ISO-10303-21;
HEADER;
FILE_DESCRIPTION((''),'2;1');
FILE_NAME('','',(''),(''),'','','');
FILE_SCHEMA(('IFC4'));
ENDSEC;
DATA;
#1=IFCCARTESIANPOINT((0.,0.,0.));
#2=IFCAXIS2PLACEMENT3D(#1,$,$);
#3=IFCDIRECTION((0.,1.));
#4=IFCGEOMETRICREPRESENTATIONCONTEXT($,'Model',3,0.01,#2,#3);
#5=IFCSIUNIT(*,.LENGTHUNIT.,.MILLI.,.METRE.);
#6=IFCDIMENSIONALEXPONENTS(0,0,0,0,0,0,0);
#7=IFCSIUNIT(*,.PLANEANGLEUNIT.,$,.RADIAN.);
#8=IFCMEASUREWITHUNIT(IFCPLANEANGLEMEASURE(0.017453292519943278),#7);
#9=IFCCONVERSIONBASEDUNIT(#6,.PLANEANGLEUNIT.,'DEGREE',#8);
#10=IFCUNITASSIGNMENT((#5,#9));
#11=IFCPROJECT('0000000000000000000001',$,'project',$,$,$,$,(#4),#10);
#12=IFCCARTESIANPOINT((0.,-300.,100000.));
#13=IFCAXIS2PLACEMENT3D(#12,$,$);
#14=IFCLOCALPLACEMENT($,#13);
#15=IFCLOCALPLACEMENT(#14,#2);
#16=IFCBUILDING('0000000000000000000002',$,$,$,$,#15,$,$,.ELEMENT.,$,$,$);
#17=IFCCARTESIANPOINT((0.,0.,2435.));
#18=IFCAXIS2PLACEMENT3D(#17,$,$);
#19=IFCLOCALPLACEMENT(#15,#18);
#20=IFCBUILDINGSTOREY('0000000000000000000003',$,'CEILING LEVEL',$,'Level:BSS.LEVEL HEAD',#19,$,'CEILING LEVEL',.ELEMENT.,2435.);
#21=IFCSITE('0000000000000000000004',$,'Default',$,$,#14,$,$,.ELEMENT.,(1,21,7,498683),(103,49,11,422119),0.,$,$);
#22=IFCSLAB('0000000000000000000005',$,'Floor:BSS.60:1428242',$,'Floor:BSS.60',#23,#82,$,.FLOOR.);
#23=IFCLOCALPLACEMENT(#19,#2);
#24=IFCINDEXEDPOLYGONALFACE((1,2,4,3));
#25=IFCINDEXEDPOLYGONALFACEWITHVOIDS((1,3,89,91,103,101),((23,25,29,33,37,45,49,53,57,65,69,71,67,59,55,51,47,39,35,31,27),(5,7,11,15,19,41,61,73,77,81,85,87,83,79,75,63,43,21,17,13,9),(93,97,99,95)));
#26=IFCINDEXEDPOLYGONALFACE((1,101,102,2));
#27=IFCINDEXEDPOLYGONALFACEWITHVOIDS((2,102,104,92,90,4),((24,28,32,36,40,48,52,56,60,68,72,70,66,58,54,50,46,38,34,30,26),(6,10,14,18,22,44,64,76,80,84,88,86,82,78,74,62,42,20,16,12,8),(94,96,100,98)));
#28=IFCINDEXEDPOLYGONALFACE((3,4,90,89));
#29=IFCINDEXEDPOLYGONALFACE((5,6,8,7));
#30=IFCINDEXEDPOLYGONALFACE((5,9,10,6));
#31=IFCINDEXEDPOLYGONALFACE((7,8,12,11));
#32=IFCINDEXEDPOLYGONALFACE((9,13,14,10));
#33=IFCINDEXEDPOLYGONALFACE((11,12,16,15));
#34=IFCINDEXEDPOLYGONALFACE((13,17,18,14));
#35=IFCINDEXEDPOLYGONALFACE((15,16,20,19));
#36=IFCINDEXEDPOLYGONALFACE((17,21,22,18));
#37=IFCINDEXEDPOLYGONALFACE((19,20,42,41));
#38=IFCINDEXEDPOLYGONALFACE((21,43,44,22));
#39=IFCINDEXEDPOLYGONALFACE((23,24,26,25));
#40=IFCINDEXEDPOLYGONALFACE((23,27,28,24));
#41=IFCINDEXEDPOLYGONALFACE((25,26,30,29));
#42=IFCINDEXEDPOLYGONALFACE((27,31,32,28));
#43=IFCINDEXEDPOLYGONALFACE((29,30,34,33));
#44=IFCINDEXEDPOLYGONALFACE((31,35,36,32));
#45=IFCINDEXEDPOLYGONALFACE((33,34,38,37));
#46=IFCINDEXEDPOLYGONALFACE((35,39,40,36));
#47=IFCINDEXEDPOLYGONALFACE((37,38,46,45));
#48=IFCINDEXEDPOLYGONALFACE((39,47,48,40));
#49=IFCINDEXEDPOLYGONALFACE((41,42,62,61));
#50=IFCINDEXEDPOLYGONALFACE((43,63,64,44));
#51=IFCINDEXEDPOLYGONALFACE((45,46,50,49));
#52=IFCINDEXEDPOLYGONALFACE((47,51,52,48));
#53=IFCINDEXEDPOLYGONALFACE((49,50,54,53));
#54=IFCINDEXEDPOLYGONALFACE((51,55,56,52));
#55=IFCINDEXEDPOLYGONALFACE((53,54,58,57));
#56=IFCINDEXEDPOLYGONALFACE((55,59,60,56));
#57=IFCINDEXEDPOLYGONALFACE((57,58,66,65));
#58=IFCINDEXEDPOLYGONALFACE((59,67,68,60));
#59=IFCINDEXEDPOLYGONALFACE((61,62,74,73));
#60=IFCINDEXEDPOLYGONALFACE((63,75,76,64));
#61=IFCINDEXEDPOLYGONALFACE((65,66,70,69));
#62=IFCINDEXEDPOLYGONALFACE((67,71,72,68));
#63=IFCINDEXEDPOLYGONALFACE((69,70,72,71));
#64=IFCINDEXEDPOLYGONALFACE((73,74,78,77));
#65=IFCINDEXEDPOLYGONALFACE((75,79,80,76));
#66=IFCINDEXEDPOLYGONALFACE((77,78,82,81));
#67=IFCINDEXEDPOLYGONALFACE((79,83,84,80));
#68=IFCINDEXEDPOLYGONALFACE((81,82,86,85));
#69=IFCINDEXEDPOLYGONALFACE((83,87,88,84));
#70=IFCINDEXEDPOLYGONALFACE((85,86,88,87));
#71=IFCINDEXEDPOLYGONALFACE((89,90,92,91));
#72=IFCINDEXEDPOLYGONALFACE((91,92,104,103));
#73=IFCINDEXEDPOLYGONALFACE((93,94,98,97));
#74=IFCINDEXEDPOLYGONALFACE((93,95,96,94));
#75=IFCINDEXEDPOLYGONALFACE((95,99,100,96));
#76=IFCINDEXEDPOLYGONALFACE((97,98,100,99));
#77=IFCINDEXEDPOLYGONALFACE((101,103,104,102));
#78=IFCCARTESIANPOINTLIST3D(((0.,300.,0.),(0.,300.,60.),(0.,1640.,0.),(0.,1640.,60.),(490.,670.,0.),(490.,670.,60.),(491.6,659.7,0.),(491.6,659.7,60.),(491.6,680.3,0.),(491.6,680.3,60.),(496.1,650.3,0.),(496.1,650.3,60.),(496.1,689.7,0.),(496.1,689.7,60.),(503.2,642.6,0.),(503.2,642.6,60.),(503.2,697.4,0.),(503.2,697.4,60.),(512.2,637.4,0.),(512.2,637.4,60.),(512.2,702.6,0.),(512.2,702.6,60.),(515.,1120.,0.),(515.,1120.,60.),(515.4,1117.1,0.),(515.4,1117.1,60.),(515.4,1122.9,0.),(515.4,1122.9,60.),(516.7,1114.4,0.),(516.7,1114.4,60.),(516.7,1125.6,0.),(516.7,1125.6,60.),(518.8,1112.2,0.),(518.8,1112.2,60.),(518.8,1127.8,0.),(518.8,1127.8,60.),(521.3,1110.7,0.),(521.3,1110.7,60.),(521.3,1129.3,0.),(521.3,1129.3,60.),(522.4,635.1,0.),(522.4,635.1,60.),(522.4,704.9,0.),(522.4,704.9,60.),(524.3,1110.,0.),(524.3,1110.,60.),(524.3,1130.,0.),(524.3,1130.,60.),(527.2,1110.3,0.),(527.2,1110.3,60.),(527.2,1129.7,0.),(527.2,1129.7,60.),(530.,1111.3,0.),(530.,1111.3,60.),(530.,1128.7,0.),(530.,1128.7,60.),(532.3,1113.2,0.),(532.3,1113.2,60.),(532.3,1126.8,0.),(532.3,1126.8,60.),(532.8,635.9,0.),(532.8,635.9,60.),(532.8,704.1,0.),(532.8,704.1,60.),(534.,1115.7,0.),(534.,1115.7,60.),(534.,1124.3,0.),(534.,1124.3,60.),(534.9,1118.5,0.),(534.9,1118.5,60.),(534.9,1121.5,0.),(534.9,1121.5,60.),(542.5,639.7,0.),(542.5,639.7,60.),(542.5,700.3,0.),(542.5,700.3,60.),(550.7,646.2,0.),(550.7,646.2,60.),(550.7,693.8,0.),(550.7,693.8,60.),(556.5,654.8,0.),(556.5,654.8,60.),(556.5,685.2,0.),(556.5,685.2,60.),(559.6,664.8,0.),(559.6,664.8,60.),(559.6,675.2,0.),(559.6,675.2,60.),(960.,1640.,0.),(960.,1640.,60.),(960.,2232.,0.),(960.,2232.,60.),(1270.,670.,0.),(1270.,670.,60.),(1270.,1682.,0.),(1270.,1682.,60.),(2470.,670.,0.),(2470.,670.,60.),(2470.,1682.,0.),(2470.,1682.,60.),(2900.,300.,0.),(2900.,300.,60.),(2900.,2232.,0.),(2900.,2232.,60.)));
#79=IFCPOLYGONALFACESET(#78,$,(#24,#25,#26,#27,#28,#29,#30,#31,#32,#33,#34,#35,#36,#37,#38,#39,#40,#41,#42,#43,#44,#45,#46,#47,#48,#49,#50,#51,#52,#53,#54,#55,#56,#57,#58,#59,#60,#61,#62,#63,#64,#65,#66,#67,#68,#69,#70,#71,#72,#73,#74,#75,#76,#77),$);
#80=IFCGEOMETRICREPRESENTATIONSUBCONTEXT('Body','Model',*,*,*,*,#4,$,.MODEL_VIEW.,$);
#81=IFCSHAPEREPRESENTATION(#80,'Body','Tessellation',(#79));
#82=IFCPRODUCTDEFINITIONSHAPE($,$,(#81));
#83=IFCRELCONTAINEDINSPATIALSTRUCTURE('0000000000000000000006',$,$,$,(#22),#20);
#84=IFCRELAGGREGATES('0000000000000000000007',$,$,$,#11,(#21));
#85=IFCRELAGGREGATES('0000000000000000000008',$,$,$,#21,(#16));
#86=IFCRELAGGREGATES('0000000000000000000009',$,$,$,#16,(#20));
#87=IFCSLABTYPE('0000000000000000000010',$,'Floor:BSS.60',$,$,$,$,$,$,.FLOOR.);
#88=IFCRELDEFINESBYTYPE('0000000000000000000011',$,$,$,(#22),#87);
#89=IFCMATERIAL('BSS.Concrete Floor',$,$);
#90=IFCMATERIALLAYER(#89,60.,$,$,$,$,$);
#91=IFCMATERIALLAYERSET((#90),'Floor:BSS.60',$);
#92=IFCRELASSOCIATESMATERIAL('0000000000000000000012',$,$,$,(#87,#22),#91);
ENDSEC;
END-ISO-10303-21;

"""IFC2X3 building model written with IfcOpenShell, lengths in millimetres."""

from ifc_helpers import new_model, entity, si_unit, converted_unit, direction, frame, frame_2d, origin, origin_2d_with_axis, place, context, subcontext, project, spatial, polyline, rectangle, circle, outline, extrude, material, layer, layer_set, layer_usage, type_object, element, save


model = new_model("IFC2X3")

# Units and contexts
model_context = context("Model", 3, precision=0.01, world=origin(), true_north=direction((0.0, 1.0)))
body_context = subcontext(model_context, "Body", "Model", "MODEL_VIEW")
ifc_project = project(units=[si_unit("LENGTHUNIT", "METRE", prefix="MILLI"), converted_unit("PLANEANGLEUNIT", "DEGREE", entity("IfcPlaneAngleMeasure", 0.017453292519943278), si_unit("PLANEANGLEUNIT", "RADIAN"), dimensions=[0, 0, 0, 0, 0, 0, 0])], contexts=[model_context])

# Site, building, storey
site_placement = place(None, frame((0.0, -300.0, 100000.0)))
site = spatial("IfcSite", under=ifc_project, at=site_placement, Name="Default", CompositionType="ELEMENT", RefLatitude=(1, 21, 7, 498683), RefLongitude=(103, 49, 11, 422119), RefElevation=0.0)
building_placement = place(site_placement, origin())
building = spatial("IfcBuilding", under=site, at=building_placement, CompositionType="ELEMENT")
storey_placement = place(building_placement, frame((0.0, 0.0, 2435.0)))
storey = spatial("IfcBuildingStorey", under=building, at=storey_placement, Name="CEILING LEVEL", ObjectType="Level:BSS.LEVEL HEAD", LongName="CEILING LEVEL", CompositionType="ELEMENT", Elevation=2435.0)

# Slab, openings
ifc_material = material(Name="BSS.Concrete Floor")
ifc_layer = layer(ifc_material, 60.0)
ifc_layer_set = layer_set([ifc_layer], Name="Floor:BSS.60")
ifc_layer_usage = layer_usage(ifc_layer_set, "AXIS3", "POSITIVE", 0.0)
slab_type = type_object("IfcSlabType", Name="Floor:BSS.60", PredefinedType="FLOOR", material=ifc_layer_set)
slab_placement = place(storey_placement, frame((0.0, 300.0, 0.0)))
slab = element("IfcSlab", 1, at=slab_placement, inside=storey, type_object=slab_type, material=ifc_layer_usage, Name="Floor:BSS.60:1428242", ObjectType="Floor:BSS.60", PredefinedType="FLOOR", context=body_context, shape_type="SweptSolid", body=[
    extrude(outline(polyline([(-1450.0, -966.0), (1450.0, -966.0), (1450.0, 374.0), (490.0, 374.0), (490.0, 966.0), (-1450.0, 966.0), (-1450.0, -966.0)])), frame((1450.0, 966.0, 60.0), z_axis=(0.0, 0.0, -1.0), x_axis=(-1.0, 0.0, 0.0)), (0.0, 0.0, 1.0), 60.0),
])
opening_1_placement = place(slab_placement, origin())
element("IfcOpeningElement", 2, at=opening_1_placement, cuts=slab, ObjectType="Opening", context=body_context, shape_type="SweptSolid", body=[
    extrude(rectangle(XDim=1200.0, YDim=1012.0, at=frame_2d((0.0, 0.0), x_axis=(1.0, 0.0))), frame((1870.0, 876.0, 60.0), z_axis=(0.0, 0.0, -1.0), x_axis=(1.0, 0.0, 0.0)), (0.0, 0.0, 1.0), 60.0),
])
opening_2_placement = place(slab_placement, origin())
element("IfcOpeningElement", 3, at=opening_2_placement, cuts=slab, ObjectType="Opening", context=body_context, shape_type="SweptSolid", body=[
    extrude(circle(Radius=10.0, at=origin_2d_with_axis()), frame((525.0, 820.0, 60.0), z_axis=(0.0, 0.0, -1.0), x_axis=(-1.0, 0.0, 0.0)), (0.0, 0.0, 1.0), 60.0),
])
opening_3_placement = place(slab_placement, origin())
element("IfcOpeningElement", 4, at=opening_3_placement, cuts=slab, ObjectType="Opening", context=body_context, shape_type="SweptSolid", body=[
    extrude(circle(Radius=35.0, at=frame_2d((0.0, 0.0), x_axis=(1.0, 0.0))), frame((525.0, 370.0, 60.0), z_axis=(0.0, 0.0, -1.0), x_axis=(-1.0, 0.0, 0.0)), (0.0, 0.0, 1.0), 60.0),
])

save(model, "model.ifc")
